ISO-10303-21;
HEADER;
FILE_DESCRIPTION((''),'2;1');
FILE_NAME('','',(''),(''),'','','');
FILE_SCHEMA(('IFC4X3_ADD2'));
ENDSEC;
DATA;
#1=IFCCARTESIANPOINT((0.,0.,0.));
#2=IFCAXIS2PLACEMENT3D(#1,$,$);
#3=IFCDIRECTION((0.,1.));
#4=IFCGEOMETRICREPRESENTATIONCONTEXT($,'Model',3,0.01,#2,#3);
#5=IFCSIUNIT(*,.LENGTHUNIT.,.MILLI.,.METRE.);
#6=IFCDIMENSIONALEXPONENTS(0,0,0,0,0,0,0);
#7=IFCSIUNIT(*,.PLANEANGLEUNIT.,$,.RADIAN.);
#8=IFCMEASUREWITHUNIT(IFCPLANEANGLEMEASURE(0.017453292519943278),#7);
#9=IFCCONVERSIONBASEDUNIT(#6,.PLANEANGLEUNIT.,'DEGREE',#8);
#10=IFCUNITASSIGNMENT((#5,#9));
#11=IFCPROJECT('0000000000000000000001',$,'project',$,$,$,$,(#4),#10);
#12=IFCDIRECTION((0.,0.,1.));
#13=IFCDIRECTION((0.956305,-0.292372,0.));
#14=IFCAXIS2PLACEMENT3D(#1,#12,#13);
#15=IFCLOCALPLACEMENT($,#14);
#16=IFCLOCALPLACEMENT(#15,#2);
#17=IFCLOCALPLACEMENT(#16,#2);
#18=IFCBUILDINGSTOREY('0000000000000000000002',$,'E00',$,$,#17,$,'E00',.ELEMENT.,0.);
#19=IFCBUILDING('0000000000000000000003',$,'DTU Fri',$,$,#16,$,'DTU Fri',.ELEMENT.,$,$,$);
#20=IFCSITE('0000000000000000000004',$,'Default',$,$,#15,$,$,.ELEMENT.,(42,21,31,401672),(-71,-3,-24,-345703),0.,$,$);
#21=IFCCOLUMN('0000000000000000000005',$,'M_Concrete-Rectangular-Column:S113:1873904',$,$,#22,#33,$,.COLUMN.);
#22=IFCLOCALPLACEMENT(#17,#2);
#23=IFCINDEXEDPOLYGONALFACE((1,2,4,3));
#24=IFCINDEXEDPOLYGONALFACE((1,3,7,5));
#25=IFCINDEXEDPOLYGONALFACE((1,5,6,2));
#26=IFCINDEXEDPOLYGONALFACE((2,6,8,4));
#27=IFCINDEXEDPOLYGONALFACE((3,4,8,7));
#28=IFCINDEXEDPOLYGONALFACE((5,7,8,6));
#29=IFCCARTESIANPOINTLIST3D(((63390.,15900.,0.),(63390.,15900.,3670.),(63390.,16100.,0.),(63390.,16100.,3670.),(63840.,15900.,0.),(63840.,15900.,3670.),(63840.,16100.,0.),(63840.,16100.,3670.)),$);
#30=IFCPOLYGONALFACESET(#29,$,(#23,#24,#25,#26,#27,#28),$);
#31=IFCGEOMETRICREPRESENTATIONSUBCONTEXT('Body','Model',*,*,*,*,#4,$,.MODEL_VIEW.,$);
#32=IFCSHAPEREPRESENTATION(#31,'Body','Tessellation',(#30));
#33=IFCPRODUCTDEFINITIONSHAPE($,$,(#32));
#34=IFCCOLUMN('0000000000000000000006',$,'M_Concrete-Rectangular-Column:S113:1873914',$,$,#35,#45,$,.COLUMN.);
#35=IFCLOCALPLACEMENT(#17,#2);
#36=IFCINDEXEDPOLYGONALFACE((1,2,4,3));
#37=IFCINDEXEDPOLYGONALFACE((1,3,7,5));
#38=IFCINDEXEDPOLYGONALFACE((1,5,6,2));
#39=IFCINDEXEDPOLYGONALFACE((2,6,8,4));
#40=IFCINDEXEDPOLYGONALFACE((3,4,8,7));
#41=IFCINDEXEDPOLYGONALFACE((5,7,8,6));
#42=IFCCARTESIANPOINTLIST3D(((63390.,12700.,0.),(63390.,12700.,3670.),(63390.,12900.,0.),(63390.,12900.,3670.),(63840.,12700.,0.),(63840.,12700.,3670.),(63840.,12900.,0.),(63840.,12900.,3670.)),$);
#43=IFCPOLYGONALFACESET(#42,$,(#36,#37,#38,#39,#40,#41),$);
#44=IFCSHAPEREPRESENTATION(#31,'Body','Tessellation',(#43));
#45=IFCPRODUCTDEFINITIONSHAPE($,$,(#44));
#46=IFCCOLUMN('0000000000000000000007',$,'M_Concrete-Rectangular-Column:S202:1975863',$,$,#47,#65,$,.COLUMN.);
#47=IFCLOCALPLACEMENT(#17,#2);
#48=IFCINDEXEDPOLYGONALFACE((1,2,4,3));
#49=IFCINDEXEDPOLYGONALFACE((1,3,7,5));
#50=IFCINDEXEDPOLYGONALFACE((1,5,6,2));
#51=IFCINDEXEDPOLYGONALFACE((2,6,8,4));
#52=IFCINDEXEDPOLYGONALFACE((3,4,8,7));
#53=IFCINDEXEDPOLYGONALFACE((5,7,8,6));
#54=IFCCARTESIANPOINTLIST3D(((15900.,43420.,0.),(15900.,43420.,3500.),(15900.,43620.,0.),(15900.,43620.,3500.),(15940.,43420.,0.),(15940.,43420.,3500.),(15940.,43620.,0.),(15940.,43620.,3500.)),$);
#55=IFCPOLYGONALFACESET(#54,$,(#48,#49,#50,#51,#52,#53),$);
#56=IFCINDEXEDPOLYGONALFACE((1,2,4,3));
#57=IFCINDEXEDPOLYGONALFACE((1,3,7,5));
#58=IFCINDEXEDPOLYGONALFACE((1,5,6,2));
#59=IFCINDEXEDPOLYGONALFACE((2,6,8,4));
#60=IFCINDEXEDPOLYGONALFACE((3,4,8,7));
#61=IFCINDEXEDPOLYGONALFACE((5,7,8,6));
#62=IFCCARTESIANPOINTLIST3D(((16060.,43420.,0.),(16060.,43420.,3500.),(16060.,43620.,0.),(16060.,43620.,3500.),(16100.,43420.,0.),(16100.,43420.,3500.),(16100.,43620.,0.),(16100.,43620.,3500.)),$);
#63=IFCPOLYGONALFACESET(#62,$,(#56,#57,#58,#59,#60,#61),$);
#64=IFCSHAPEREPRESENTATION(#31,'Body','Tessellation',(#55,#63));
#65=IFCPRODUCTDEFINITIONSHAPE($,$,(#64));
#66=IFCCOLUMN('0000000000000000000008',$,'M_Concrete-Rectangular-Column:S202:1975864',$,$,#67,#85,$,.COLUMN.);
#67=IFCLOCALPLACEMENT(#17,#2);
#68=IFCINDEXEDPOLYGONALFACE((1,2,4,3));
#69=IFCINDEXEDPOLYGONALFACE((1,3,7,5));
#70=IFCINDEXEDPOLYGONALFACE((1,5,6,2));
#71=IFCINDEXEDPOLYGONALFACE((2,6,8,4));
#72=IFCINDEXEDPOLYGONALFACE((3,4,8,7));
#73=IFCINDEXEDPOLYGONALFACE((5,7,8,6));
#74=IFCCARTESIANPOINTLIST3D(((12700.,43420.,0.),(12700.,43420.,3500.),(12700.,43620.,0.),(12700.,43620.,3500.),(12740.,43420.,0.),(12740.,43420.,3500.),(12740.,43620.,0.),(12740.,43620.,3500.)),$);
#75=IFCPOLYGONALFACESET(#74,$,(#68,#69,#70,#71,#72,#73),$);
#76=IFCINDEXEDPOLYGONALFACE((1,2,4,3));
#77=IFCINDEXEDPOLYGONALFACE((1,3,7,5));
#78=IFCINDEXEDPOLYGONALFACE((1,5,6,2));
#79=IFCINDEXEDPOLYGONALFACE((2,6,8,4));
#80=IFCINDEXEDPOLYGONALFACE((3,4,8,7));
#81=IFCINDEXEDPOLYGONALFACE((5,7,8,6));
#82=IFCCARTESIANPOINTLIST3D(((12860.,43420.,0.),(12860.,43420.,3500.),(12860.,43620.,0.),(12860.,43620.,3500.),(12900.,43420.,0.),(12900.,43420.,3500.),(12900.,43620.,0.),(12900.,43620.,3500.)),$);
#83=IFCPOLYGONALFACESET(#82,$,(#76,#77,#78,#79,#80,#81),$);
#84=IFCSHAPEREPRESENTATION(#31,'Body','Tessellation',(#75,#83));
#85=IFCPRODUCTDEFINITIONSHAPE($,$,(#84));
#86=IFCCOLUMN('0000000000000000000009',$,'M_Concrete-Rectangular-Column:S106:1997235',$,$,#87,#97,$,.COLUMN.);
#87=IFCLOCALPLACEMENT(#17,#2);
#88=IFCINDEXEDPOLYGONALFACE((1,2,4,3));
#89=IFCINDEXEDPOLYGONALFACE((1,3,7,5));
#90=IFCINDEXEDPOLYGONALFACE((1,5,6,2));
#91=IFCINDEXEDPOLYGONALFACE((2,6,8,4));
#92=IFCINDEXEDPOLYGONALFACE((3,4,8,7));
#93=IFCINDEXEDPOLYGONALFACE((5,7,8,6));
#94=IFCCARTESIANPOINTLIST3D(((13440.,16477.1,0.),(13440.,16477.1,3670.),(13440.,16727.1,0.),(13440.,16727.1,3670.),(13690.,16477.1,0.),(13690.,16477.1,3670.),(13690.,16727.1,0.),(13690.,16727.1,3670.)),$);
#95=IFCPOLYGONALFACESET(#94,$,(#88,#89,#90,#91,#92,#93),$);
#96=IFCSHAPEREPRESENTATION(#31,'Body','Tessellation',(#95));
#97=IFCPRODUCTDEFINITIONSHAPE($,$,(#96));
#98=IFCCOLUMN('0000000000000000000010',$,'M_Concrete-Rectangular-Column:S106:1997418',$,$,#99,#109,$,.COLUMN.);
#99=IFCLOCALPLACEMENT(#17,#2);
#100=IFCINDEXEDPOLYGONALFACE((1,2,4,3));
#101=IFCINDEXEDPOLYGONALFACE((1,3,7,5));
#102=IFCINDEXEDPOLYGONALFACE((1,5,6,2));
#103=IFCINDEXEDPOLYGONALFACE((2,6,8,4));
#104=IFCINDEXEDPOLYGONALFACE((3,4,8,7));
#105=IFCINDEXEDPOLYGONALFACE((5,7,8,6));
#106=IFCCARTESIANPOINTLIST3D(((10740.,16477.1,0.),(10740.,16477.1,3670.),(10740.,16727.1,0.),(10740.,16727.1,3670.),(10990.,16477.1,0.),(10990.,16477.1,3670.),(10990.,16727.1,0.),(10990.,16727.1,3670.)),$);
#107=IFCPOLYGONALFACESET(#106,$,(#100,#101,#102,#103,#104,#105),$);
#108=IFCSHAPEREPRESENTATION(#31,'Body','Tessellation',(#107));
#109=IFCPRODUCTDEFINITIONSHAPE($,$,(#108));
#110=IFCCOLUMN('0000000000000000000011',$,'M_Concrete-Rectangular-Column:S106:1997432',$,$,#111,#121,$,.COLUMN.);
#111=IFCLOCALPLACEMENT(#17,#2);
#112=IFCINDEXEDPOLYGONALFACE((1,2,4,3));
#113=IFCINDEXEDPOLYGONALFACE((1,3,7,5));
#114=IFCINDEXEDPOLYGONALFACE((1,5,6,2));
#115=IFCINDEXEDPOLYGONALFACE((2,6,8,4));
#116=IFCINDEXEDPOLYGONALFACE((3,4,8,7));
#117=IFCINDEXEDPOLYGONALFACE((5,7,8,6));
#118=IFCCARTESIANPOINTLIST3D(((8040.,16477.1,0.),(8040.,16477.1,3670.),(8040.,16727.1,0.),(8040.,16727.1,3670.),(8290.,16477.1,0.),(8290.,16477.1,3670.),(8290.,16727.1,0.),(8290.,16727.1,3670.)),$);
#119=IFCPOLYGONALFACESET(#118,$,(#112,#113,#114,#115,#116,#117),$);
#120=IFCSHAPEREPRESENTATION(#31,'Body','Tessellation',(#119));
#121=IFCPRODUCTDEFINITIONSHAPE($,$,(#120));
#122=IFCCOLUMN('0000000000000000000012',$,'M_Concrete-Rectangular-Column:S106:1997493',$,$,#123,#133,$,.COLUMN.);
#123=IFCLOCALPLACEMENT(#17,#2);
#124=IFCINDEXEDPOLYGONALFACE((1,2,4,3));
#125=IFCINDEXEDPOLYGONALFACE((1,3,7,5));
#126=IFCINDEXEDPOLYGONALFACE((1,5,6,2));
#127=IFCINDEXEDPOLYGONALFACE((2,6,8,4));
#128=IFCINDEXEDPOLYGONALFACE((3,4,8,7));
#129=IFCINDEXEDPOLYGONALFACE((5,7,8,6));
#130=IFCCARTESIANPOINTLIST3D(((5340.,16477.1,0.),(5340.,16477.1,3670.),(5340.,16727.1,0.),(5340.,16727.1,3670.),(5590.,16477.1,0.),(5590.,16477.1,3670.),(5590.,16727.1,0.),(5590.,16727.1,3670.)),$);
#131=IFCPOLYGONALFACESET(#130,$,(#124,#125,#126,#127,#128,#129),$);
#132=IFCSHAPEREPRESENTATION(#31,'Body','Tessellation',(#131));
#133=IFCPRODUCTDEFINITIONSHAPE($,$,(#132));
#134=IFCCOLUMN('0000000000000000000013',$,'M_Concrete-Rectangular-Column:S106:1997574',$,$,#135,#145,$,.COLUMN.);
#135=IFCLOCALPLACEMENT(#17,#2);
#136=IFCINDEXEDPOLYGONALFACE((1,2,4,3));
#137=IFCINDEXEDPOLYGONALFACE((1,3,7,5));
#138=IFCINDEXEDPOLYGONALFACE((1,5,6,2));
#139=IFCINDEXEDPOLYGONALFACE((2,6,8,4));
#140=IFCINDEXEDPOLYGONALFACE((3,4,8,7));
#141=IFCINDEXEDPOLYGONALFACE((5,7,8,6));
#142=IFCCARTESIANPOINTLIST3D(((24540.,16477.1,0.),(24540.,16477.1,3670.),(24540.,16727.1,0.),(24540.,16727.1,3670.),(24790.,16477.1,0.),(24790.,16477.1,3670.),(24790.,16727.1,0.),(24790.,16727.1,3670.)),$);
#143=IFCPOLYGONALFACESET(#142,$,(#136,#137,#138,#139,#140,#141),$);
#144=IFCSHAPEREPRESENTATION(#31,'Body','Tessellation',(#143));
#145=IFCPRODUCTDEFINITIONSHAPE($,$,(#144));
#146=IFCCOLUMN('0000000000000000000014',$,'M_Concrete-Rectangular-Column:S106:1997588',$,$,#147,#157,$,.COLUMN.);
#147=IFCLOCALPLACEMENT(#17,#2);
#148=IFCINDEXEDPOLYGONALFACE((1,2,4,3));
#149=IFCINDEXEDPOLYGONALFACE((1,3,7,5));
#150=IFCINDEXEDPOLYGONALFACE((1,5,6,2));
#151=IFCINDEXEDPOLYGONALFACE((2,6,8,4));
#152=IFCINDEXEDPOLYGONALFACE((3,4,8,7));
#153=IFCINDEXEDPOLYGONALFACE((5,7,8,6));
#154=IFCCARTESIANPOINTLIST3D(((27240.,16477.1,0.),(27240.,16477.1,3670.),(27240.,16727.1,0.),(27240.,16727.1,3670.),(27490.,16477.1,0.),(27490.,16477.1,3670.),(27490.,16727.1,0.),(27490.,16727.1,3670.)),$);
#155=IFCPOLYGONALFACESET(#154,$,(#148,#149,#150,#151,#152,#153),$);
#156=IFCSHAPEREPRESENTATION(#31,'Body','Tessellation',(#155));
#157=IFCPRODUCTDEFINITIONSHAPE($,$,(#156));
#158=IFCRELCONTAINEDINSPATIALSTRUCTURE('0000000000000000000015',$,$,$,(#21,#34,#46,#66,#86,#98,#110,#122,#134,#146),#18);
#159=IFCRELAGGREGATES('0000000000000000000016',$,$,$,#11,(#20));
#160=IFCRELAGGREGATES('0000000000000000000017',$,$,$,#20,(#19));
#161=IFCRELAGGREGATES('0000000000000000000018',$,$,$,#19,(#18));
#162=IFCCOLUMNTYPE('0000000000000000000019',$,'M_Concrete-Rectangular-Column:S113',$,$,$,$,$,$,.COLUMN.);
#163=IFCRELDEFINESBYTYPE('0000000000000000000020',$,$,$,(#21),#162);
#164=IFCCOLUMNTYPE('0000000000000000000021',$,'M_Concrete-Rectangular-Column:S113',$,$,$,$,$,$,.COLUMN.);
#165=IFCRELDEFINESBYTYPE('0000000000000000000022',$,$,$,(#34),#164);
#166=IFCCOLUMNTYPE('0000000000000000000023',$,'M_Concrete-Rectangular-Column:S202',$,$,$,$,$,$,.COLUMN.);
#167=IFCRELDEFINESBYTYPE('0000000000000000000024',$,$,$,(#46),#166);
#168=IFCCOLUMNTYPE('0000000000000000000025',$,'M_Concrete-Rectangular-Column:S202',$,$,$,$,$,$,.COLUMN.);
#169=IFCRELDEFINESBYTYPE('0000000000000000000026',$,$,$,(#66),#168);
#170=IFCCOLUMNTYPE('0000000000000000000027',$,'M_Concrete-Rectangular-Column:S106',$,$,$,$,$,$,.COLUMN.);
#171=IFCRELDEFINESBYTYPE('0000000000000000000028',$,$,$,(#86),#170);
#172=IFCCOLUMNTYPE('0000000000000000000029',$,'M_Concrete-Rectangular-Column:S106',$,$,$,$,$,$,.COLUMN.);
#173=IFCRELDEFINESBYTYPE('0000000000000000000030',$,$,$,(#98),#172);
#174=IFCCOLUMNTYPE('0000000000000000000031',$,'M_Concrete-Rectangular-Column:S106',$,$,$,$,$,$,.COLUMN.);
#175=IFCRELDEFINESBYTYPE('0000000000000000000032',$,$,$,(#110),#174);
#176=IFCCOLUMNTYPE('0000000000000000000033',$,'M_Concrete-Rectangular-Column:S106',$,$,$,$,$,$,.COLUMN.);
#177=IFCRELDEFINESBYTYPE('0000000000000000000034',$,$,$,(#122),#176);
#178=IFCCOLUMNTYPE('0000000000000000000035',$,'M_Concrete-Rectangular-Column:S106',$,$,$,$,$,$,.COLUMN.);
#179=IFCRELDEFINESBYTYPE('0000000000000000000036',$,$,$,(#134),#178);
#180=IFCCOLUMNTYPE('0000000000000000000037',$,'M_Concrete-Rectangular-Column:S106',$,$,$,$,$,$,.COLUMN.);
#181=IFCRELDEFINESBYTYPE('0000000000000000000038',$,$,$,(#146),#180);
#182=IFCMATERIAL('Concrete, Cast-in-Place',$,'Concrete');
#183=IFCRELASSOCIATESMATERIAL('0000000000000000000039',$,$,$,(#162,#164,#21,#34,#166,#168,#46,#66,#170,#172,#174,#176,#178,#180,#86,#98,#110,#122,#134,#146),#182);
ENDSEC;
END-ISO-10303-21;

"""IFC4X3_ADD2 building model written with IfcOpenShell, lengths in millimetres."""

from ifc_helpers import new_model, entity, si_unit, converted_unit, direction, frame, frame_2d, origin, origin_2d_with_axis, place, context, subcontext, project, spatial, rectangle, extrude, source, transform, mapped, material, material_profile, profile_set, profile_usage, type_object, type_shapes, element, save


model = new_model("IFC4X3_ADD2")

# Units and contexts
model_context = context("Model", 3, precision=0.01, world=origin(), true_north=direction((0.0, 1.0)))
body_context = subcontext(model_context, "Body", "Model", "MODEL_VIEW")
ifc_project = project(units=[si_unit("LENGTHUNIT", "METRE", prefix="MILLI"), converted_unit("PLANEANGLEUNIT", "DEGREE", entity("IfcPlaneAngleMeasure", 0.017453292519943278), si_unit("PLANEANGLEUNIT", "RADIAN"), dimensions=[0, 0, 0, 0, 0, 0, 0])], contexts=[model_context])

# Site, building, storey
site_placement = place(None, frame((0.0, 0.0, 0.0), z_axis=(0.0, 0.0, 1.0), x_axis=(0.956305, -0.292372, 0.0)))
site = spatial("IfcSite", under=ifc_project, at=site_placement, Name="Default", CompositionType="ELEMENT", RefLatitude=(42, 21, 31, 401672), RefLongitude=(-71, -3, -24, -345703), RefElevation=0.0)
building_placement = place(site_placement, origin())
building = spatial("IfcBuilding", under=site, at=building_placement, Name="DTU Fri", LongName="DTU Fri", CompositionType="ELEMENT")
storey_placement = place(building_placement, origin())
storey = spatial("IfcBuildingStorey", under=building, at=storey_placement, Name="E00", LongName="E00", CompositionType="ELEMENT", Elevation=0.0)

# Columns
ifc_material = material(Name="Concrete, Cast-in-Place", Category="Concrete")
ifc_material_profile_1 = material_profile(ifc_material, rectangle(XDim=200.0, YDim=450.0, at=origin_2d_with_axis()), Name="S113")
ifc_profile_set_1 = profile_set([ifc_material_profile_1], Name="S113")
ifc_profile_usage_1 = profile_usage(ifc_profile_set_1)
column_type_1 = type_object("IfcColumnType", Name="M_Concrete-Rectangular-Column:S113", PredefinedType="COLUMN", material=ifc_profile_set_1)
shared_shape_1 = source(origin(), body_context, "Body", "SweptSolid", [
    extrude(rectangle(XDim=200.0, YDim=450.0, at=origin_2d_with_axis()), frame((63615.0, 16000.0, 0.0), z_axis=(0.0, 0.0, 1.0), x_axis=(0.0, 1.0, 0.0)), (0.0, 0.0, 1.0), 3670.0),
])
type_shapes(column_type_1, [shared_shape_1])
column_1_placement = place(storey_placement, origin())
element("IfcColumn", 1, at=column_1_placement, inside=storey, type_object=column_type_1, material=ifc_profile_usage_1, Name="M_Concrete-Rectangular-Column:S113:1873904", PredefinedType="COLUMN", context=body_context, shape_type="MappedRepresentation", body=[
    mapped(shared_shape_1, transform((0.0, 0.0, 0.0), scale=1.0)),
])
column_type_2 = type_object("IfcColumnType", Name="M_Concrete-Rectangular-Column:S113", PredefinedType="COLUMN", material=ifc_profile_set_1)
shared_shape_2 = source(origin(), body_context, "Body", "SweptSolid", [
    extrude(rectangle(XDim=200.0, YDim=450.0, at=origin_2d_with_axis()), frame((63615.0, 12800.0, 0.0), z_axis=(0.0, 0.0, 1.0), x_axis=(0.0, 1.0, 0.0)), (0.0, 0.0, 1.0), 3670.0),
])
type_shapes(column_type_2, [shared_shape_2])
column_2_placement = place(storey_placement, origin())
element("IfcColumn", 2, at=column_2_placement, inside=storey, type_object=column_type_2, material=ifc_profile_usage_1, Name="M_Concrete-Rectangular-Column:S113:1873914", PredefinedType="COLUMN", context=body_context, shape_type="MappedRepresentation", body=[
    mapped(shared_shape_2, transform((0.0, 0.0, 0.0), scale=1.0)),
])
ifc_material_profile_2 = material_profile(ifc_material, rectangle(XDim=200.0, YDim=200.0, at=frame_2d((0.0, 0.0), x_axis=(1.0, 0.0))), Name="S202")
ifc_profile_set_2 = profile_set([ifc_material_profile_2], Name="S202")
ifc_profile_usage_2 = profile_usage(ifc_profile_set_2)
column_type_3 = type_object("IfcColumnType", Name="M_Concrete-Rectangular-Column:S202", PredefinedType="COLUMN", material=ifc_profile_set_2)
shared_shape_3 = source(origin(), body_context, "Body", "SweptSolid", [
    extrude(rectangle(XDim=40.0, YDim=200.0, at=frame_2d((0.0, 0.0), x_axis=(1.0, 0.0))), frame((15920.0, 43520.0, 0.0)), (0.0, 0.0, 1.0), 3500.0),
    extrude(rectangle(XDim=40.0, YDim=200.0, at=frame_2d((0.0, 0.0), x_axis=(1.0, 0.0))), frame((16080.0, 43520.0, 0.0), z_axis=(0.0, 0.0, 1.0), x_axis=(-1.0, 0.0, 0.0)), (0.0, 0.0, 1.0), 3500.0),
])
type_shapes(column_type_3, [shared_shape_3])
column_3_placement = place(storey_placement, origin())
element("IfcColumn", 3, at=column_3_placement, inside=storey, type_object=column_type_3, material=ifc_profile_usage_2, Name="M_Concrete-Rectangular-Column:S202:1975863", PredefinedType="COLUMN", context=body_context, shape_type="MappedRepresentation", body=[
    mapped(shared_shape_3, transform((0.0, 0.0, 0.0), scale=1.0)),
])
column_type_4 = type_object("IfcColumnType", Name="M_Concrete-Rectangular-Column:S202", PredefinedType="COLUMN", material=ifc_profile_set_2)
shared_shape_4 = source(origin(), body_context, "Body", "SweptSolid", [
    extrude(rectangle(XDim=40.0, YDim=200.0, at=frame_2d((0.0, 0.0), x_axis=(1.0, 0.0))), frame((12720.0, 43520.0, 0.0)), (0.0, 0.0, 1.0), 3500.0),
    extrude(rectangle(XDim=40.0, YDim=200.0, at=frame_2d((0.0, 0.0), x_axis=(1.0, 0.0))), frame((12880.0, 43520.0, 0.0), z_axis=(0.0, 0.0, 1.0), x_axis=(-1.0, 0.0, 0.0)), (0.0, 0.0, 1.0), 3500.0),
])
type_shapes(column_type_4, [shared_shape_4])
column_4_placement = place(storey_placement, origin())
element("IfcColumn", 4, at=column_4_placement, inside=storey, type_object=column_type_4, material=ifc_profile_usage_2, Name="M_Concrete-Rectangular-Column:S202:1975864", PredefinedType="COLUMN", context=body_context, shape_type="MappedRepresentation", body=[
    mapped(shared_shape_4, transform((0.0, 0.0, 0.0), scale=1.0)),
])
ifc_material_profile_3 = material_profile(ifc_material, rectangle(XDim=250.0, YDim=250.0, at=frame_2d((0.0, 0.0), x_axis=(1.0, 0.0))), Name="S106")
ifc_profile_set_3 = profile_set([ifc_material_profile_3], Name="S106")
ifc_profile_usage_3 = profile_usage(ifc_profile_set_3)
column_type_5 = type_object("IfcColumnType", Name="M_Concrete-Rectangular-Column:S106", PredefinedType="COLUMN", material=ifc_profile_set_3)
shared_shape_5 = source(origin(), body_context, "Body", "SweptSolid", [
    extrude(rectangle(XDim=250.0, YDim=250.0, at=frame_2d((0.0, 0.0), x_axis=(1.0, 0.0))), frame((13565.0, 16602.1, 0.0), z_axis=(0.0, 0.0, 1.0), x_axis=(0.0, 1.0, 0.0)), (0.0, 0.0, 1.0), 3670.0),
])
type_shapes(column_type_5, [shared_shape_5])
column_5_placement = place(storey_placement, origin())
element("IfcColumn", 5, at=column_5_placement, inside=storey, type_object=column_type_5, material=ifc_profile_usage_3, Name="M_Concrete-Rectangular-Column:S106:1997235", PredefinedType="COLUMN", context=body_context, shape_type="MappedRepresentation", body=[
    mapped(shared_shape_5, transform((0.0, 0.0, 0.0), scale=1.0)),
])
column_type_6 = type_object("IfcColumnType", Name="M_Concrete-Rectangular-Column:S106", PredefinedType="COLUMN", material=ifc_profile_set_3)
shared_shape_6 = source(origin(), body_context, "Body", "SweptSolid", [
    extrude(rectangle(XDim=250.0, YDim=250.0, at=frame_2d((0.0, 0.0), x_axis=(1.0, 0.0))), frame((10865.0, 16602.1, 0.0), z_axis=(0.0, 0.0, 1.0), x_axis=(0.0, 1.0, 0.0)), (0.0, 0.0, 1.0), 3670.0),
])
type_shapes(column_type_6, [shared_shape_6])
column_6_placement = place(storey_placement, origin())
element("IfcColumn", 6, at=column_6_placement, inside=storey, type_object=column_type_6, material=ifc_profile_usage_3, Name="M_Concrete-Rectangular-Column:S106:1997418", PredefinedType="COLUMN", context=body_context, shape_type="MappedRepresentation", body=[
    mapped(shared_shape_6, transform((0.0, 0.0, 0.0), scale=1.0)),
])
column_type_7 = type_object("IfcColumnType", Name="M_Concrete-Rectangular-Column:S106", PredefinedType="COLUMN", material=ifc_profile_set_3)
shared_shape_7 = source(origin(), body_context, "Body", "SweptSolid", [
    extrude(rectangle(XDim=250.0, YDim=250.0, at=frame_2d((0.0, 0.0), x_axis=(1.0, 0.0))), frame((8165.0, 16602.1, 0.0), z_axis=(0.0, 0.0, 1.0), x_axis=(0.0, 1.0, 0.0)), (0.0, 0.0, 1.0), 3670.0),
])
type_shapes(column_type_7, [shared_shape_7])
column_7_placement = place(storey_placement, origin())
element("IfcColumn", 7, at=column_7_placement, inside=storey, type_object=column_type_7, material=ifc_profile_usage_3, Name="M_Concrete-Rectangular-Column:S106:1997432", PredefinedType="COLUMN", context=body_context, shape_type="MappedRepresentation", body=[
    mapped(shared_shape_7, transform((0.0, 0.0, 0.0), scale=1.0)),
])
column_type_8 = type_object("IfcColumnType", Name="M_Concrete-Rectangular-Column:S106", PredefinedType="COLUMN", material=ifc_profile_set_3)
shared_shape_8 = source(origin(), body_context, "Body", "SweptSolid", [
    extrude(rectangle(XDim=250.0, YDim=250.0, at=frame_2d((0.0, 0.0), x_axis=(1.0, 0.0))), frame((5465.0, 16602.1, 0.0), z_axis=(0.0, 0.0, 1.0), x_axis=(0.0, 1.0, 0.0)), (0.0, 0.0, 1.0), 3670.0),
])
type_shapes(column_type_8, [shared_shape_8])
column_8_placement = place(storey_placement, origin())
element("IfcColumn", 8, at=column_8_placement, inside=storey, type_object=column_type_8, material=ifc_profile_usage_3, Name="M_Concrete-Rectangular-Column:S106:1997493", PredefinedType="COLUMN", context=body_context, shape_type="MappedRepresentation", body=[
    mapped(shared_shape_8, transform((0.0, 0.0, 0.0), scale=1.0)),
])
column_type_9 = type_object("IfcColumnType", Name="M_Concrete-Rectangular-Column:S106", PredefinedType="COLUMN", material=ifc_profile_set_3)
shared_shape_9 = source(origin(), body_context, "Body", "SweptSolid", [
    extrude(rectangle(XDim=250.0, YDim=250.0, at=origin_2d_with_axis()), frame((24665.0, 16602.1, 0.0), z_axis=(0.0, 0.0, 1.0), x_axis=(0.0, 1.0, 0.0)), (0.0, 0.0, 1.0), 3670.0),
])
type_shapes(column_type_9, [shared_shape_9])
column_9_placement = place(storey_placement, origin())
element("IfcColumn", 9, at=column_9_placement, inside=storey, type_object=column_type_9, material=ifc_profile_usage_3, Name="M_Concrete-Rectangular-Column:S106:1997574", PredefinedType="COLUMN", context=body_context, shape_type="MappedRepresentation", body=[
    mapped(shared_shape_9, transform((0.0, 0.0, 0.0), scale=1.0)),
])
column_type_10 = type_object("IfcColumnType", Name="M_Concrete-Rectangular-Column:S106", PredefinedType="COLUMN", material=ifc_profile_set_3)
shared_shape_10 = source(origin(), body_context, "Body", "SweptSolid", [
    extrude(rectangle(XDim=250.0, YDim=250.0, at=frame_2d((0.0, 0.0), x_axis=(1.0, 0.0))), frame((27365.0, 16602.1, 0.0), z_axis=(0.0, 0.0, 1.0), x_axis=(0.0, 1.0, 0.0)), (0.0, 0.0, 1.0), 3670.0),
])
type_shapes(column_type_10, [shared_shape_10])
column_10_placement = place(storey_placement, origin())
element("IfcColumn", 10, at=column_10_placement, inside=storey, type_object=column_type_10, material=ifc_profile_usage_3, Name="M_Concrete-Rectangular-Column:S106:1997588", PredefinedType="COLUMN", context=body_context, shape_type="MappedRepresentation", body=[
    mapped(shared_shape_10, transform((0.0, 0.0, 0.0), scale=1.0)),
])

save(model, "model.ifc")
